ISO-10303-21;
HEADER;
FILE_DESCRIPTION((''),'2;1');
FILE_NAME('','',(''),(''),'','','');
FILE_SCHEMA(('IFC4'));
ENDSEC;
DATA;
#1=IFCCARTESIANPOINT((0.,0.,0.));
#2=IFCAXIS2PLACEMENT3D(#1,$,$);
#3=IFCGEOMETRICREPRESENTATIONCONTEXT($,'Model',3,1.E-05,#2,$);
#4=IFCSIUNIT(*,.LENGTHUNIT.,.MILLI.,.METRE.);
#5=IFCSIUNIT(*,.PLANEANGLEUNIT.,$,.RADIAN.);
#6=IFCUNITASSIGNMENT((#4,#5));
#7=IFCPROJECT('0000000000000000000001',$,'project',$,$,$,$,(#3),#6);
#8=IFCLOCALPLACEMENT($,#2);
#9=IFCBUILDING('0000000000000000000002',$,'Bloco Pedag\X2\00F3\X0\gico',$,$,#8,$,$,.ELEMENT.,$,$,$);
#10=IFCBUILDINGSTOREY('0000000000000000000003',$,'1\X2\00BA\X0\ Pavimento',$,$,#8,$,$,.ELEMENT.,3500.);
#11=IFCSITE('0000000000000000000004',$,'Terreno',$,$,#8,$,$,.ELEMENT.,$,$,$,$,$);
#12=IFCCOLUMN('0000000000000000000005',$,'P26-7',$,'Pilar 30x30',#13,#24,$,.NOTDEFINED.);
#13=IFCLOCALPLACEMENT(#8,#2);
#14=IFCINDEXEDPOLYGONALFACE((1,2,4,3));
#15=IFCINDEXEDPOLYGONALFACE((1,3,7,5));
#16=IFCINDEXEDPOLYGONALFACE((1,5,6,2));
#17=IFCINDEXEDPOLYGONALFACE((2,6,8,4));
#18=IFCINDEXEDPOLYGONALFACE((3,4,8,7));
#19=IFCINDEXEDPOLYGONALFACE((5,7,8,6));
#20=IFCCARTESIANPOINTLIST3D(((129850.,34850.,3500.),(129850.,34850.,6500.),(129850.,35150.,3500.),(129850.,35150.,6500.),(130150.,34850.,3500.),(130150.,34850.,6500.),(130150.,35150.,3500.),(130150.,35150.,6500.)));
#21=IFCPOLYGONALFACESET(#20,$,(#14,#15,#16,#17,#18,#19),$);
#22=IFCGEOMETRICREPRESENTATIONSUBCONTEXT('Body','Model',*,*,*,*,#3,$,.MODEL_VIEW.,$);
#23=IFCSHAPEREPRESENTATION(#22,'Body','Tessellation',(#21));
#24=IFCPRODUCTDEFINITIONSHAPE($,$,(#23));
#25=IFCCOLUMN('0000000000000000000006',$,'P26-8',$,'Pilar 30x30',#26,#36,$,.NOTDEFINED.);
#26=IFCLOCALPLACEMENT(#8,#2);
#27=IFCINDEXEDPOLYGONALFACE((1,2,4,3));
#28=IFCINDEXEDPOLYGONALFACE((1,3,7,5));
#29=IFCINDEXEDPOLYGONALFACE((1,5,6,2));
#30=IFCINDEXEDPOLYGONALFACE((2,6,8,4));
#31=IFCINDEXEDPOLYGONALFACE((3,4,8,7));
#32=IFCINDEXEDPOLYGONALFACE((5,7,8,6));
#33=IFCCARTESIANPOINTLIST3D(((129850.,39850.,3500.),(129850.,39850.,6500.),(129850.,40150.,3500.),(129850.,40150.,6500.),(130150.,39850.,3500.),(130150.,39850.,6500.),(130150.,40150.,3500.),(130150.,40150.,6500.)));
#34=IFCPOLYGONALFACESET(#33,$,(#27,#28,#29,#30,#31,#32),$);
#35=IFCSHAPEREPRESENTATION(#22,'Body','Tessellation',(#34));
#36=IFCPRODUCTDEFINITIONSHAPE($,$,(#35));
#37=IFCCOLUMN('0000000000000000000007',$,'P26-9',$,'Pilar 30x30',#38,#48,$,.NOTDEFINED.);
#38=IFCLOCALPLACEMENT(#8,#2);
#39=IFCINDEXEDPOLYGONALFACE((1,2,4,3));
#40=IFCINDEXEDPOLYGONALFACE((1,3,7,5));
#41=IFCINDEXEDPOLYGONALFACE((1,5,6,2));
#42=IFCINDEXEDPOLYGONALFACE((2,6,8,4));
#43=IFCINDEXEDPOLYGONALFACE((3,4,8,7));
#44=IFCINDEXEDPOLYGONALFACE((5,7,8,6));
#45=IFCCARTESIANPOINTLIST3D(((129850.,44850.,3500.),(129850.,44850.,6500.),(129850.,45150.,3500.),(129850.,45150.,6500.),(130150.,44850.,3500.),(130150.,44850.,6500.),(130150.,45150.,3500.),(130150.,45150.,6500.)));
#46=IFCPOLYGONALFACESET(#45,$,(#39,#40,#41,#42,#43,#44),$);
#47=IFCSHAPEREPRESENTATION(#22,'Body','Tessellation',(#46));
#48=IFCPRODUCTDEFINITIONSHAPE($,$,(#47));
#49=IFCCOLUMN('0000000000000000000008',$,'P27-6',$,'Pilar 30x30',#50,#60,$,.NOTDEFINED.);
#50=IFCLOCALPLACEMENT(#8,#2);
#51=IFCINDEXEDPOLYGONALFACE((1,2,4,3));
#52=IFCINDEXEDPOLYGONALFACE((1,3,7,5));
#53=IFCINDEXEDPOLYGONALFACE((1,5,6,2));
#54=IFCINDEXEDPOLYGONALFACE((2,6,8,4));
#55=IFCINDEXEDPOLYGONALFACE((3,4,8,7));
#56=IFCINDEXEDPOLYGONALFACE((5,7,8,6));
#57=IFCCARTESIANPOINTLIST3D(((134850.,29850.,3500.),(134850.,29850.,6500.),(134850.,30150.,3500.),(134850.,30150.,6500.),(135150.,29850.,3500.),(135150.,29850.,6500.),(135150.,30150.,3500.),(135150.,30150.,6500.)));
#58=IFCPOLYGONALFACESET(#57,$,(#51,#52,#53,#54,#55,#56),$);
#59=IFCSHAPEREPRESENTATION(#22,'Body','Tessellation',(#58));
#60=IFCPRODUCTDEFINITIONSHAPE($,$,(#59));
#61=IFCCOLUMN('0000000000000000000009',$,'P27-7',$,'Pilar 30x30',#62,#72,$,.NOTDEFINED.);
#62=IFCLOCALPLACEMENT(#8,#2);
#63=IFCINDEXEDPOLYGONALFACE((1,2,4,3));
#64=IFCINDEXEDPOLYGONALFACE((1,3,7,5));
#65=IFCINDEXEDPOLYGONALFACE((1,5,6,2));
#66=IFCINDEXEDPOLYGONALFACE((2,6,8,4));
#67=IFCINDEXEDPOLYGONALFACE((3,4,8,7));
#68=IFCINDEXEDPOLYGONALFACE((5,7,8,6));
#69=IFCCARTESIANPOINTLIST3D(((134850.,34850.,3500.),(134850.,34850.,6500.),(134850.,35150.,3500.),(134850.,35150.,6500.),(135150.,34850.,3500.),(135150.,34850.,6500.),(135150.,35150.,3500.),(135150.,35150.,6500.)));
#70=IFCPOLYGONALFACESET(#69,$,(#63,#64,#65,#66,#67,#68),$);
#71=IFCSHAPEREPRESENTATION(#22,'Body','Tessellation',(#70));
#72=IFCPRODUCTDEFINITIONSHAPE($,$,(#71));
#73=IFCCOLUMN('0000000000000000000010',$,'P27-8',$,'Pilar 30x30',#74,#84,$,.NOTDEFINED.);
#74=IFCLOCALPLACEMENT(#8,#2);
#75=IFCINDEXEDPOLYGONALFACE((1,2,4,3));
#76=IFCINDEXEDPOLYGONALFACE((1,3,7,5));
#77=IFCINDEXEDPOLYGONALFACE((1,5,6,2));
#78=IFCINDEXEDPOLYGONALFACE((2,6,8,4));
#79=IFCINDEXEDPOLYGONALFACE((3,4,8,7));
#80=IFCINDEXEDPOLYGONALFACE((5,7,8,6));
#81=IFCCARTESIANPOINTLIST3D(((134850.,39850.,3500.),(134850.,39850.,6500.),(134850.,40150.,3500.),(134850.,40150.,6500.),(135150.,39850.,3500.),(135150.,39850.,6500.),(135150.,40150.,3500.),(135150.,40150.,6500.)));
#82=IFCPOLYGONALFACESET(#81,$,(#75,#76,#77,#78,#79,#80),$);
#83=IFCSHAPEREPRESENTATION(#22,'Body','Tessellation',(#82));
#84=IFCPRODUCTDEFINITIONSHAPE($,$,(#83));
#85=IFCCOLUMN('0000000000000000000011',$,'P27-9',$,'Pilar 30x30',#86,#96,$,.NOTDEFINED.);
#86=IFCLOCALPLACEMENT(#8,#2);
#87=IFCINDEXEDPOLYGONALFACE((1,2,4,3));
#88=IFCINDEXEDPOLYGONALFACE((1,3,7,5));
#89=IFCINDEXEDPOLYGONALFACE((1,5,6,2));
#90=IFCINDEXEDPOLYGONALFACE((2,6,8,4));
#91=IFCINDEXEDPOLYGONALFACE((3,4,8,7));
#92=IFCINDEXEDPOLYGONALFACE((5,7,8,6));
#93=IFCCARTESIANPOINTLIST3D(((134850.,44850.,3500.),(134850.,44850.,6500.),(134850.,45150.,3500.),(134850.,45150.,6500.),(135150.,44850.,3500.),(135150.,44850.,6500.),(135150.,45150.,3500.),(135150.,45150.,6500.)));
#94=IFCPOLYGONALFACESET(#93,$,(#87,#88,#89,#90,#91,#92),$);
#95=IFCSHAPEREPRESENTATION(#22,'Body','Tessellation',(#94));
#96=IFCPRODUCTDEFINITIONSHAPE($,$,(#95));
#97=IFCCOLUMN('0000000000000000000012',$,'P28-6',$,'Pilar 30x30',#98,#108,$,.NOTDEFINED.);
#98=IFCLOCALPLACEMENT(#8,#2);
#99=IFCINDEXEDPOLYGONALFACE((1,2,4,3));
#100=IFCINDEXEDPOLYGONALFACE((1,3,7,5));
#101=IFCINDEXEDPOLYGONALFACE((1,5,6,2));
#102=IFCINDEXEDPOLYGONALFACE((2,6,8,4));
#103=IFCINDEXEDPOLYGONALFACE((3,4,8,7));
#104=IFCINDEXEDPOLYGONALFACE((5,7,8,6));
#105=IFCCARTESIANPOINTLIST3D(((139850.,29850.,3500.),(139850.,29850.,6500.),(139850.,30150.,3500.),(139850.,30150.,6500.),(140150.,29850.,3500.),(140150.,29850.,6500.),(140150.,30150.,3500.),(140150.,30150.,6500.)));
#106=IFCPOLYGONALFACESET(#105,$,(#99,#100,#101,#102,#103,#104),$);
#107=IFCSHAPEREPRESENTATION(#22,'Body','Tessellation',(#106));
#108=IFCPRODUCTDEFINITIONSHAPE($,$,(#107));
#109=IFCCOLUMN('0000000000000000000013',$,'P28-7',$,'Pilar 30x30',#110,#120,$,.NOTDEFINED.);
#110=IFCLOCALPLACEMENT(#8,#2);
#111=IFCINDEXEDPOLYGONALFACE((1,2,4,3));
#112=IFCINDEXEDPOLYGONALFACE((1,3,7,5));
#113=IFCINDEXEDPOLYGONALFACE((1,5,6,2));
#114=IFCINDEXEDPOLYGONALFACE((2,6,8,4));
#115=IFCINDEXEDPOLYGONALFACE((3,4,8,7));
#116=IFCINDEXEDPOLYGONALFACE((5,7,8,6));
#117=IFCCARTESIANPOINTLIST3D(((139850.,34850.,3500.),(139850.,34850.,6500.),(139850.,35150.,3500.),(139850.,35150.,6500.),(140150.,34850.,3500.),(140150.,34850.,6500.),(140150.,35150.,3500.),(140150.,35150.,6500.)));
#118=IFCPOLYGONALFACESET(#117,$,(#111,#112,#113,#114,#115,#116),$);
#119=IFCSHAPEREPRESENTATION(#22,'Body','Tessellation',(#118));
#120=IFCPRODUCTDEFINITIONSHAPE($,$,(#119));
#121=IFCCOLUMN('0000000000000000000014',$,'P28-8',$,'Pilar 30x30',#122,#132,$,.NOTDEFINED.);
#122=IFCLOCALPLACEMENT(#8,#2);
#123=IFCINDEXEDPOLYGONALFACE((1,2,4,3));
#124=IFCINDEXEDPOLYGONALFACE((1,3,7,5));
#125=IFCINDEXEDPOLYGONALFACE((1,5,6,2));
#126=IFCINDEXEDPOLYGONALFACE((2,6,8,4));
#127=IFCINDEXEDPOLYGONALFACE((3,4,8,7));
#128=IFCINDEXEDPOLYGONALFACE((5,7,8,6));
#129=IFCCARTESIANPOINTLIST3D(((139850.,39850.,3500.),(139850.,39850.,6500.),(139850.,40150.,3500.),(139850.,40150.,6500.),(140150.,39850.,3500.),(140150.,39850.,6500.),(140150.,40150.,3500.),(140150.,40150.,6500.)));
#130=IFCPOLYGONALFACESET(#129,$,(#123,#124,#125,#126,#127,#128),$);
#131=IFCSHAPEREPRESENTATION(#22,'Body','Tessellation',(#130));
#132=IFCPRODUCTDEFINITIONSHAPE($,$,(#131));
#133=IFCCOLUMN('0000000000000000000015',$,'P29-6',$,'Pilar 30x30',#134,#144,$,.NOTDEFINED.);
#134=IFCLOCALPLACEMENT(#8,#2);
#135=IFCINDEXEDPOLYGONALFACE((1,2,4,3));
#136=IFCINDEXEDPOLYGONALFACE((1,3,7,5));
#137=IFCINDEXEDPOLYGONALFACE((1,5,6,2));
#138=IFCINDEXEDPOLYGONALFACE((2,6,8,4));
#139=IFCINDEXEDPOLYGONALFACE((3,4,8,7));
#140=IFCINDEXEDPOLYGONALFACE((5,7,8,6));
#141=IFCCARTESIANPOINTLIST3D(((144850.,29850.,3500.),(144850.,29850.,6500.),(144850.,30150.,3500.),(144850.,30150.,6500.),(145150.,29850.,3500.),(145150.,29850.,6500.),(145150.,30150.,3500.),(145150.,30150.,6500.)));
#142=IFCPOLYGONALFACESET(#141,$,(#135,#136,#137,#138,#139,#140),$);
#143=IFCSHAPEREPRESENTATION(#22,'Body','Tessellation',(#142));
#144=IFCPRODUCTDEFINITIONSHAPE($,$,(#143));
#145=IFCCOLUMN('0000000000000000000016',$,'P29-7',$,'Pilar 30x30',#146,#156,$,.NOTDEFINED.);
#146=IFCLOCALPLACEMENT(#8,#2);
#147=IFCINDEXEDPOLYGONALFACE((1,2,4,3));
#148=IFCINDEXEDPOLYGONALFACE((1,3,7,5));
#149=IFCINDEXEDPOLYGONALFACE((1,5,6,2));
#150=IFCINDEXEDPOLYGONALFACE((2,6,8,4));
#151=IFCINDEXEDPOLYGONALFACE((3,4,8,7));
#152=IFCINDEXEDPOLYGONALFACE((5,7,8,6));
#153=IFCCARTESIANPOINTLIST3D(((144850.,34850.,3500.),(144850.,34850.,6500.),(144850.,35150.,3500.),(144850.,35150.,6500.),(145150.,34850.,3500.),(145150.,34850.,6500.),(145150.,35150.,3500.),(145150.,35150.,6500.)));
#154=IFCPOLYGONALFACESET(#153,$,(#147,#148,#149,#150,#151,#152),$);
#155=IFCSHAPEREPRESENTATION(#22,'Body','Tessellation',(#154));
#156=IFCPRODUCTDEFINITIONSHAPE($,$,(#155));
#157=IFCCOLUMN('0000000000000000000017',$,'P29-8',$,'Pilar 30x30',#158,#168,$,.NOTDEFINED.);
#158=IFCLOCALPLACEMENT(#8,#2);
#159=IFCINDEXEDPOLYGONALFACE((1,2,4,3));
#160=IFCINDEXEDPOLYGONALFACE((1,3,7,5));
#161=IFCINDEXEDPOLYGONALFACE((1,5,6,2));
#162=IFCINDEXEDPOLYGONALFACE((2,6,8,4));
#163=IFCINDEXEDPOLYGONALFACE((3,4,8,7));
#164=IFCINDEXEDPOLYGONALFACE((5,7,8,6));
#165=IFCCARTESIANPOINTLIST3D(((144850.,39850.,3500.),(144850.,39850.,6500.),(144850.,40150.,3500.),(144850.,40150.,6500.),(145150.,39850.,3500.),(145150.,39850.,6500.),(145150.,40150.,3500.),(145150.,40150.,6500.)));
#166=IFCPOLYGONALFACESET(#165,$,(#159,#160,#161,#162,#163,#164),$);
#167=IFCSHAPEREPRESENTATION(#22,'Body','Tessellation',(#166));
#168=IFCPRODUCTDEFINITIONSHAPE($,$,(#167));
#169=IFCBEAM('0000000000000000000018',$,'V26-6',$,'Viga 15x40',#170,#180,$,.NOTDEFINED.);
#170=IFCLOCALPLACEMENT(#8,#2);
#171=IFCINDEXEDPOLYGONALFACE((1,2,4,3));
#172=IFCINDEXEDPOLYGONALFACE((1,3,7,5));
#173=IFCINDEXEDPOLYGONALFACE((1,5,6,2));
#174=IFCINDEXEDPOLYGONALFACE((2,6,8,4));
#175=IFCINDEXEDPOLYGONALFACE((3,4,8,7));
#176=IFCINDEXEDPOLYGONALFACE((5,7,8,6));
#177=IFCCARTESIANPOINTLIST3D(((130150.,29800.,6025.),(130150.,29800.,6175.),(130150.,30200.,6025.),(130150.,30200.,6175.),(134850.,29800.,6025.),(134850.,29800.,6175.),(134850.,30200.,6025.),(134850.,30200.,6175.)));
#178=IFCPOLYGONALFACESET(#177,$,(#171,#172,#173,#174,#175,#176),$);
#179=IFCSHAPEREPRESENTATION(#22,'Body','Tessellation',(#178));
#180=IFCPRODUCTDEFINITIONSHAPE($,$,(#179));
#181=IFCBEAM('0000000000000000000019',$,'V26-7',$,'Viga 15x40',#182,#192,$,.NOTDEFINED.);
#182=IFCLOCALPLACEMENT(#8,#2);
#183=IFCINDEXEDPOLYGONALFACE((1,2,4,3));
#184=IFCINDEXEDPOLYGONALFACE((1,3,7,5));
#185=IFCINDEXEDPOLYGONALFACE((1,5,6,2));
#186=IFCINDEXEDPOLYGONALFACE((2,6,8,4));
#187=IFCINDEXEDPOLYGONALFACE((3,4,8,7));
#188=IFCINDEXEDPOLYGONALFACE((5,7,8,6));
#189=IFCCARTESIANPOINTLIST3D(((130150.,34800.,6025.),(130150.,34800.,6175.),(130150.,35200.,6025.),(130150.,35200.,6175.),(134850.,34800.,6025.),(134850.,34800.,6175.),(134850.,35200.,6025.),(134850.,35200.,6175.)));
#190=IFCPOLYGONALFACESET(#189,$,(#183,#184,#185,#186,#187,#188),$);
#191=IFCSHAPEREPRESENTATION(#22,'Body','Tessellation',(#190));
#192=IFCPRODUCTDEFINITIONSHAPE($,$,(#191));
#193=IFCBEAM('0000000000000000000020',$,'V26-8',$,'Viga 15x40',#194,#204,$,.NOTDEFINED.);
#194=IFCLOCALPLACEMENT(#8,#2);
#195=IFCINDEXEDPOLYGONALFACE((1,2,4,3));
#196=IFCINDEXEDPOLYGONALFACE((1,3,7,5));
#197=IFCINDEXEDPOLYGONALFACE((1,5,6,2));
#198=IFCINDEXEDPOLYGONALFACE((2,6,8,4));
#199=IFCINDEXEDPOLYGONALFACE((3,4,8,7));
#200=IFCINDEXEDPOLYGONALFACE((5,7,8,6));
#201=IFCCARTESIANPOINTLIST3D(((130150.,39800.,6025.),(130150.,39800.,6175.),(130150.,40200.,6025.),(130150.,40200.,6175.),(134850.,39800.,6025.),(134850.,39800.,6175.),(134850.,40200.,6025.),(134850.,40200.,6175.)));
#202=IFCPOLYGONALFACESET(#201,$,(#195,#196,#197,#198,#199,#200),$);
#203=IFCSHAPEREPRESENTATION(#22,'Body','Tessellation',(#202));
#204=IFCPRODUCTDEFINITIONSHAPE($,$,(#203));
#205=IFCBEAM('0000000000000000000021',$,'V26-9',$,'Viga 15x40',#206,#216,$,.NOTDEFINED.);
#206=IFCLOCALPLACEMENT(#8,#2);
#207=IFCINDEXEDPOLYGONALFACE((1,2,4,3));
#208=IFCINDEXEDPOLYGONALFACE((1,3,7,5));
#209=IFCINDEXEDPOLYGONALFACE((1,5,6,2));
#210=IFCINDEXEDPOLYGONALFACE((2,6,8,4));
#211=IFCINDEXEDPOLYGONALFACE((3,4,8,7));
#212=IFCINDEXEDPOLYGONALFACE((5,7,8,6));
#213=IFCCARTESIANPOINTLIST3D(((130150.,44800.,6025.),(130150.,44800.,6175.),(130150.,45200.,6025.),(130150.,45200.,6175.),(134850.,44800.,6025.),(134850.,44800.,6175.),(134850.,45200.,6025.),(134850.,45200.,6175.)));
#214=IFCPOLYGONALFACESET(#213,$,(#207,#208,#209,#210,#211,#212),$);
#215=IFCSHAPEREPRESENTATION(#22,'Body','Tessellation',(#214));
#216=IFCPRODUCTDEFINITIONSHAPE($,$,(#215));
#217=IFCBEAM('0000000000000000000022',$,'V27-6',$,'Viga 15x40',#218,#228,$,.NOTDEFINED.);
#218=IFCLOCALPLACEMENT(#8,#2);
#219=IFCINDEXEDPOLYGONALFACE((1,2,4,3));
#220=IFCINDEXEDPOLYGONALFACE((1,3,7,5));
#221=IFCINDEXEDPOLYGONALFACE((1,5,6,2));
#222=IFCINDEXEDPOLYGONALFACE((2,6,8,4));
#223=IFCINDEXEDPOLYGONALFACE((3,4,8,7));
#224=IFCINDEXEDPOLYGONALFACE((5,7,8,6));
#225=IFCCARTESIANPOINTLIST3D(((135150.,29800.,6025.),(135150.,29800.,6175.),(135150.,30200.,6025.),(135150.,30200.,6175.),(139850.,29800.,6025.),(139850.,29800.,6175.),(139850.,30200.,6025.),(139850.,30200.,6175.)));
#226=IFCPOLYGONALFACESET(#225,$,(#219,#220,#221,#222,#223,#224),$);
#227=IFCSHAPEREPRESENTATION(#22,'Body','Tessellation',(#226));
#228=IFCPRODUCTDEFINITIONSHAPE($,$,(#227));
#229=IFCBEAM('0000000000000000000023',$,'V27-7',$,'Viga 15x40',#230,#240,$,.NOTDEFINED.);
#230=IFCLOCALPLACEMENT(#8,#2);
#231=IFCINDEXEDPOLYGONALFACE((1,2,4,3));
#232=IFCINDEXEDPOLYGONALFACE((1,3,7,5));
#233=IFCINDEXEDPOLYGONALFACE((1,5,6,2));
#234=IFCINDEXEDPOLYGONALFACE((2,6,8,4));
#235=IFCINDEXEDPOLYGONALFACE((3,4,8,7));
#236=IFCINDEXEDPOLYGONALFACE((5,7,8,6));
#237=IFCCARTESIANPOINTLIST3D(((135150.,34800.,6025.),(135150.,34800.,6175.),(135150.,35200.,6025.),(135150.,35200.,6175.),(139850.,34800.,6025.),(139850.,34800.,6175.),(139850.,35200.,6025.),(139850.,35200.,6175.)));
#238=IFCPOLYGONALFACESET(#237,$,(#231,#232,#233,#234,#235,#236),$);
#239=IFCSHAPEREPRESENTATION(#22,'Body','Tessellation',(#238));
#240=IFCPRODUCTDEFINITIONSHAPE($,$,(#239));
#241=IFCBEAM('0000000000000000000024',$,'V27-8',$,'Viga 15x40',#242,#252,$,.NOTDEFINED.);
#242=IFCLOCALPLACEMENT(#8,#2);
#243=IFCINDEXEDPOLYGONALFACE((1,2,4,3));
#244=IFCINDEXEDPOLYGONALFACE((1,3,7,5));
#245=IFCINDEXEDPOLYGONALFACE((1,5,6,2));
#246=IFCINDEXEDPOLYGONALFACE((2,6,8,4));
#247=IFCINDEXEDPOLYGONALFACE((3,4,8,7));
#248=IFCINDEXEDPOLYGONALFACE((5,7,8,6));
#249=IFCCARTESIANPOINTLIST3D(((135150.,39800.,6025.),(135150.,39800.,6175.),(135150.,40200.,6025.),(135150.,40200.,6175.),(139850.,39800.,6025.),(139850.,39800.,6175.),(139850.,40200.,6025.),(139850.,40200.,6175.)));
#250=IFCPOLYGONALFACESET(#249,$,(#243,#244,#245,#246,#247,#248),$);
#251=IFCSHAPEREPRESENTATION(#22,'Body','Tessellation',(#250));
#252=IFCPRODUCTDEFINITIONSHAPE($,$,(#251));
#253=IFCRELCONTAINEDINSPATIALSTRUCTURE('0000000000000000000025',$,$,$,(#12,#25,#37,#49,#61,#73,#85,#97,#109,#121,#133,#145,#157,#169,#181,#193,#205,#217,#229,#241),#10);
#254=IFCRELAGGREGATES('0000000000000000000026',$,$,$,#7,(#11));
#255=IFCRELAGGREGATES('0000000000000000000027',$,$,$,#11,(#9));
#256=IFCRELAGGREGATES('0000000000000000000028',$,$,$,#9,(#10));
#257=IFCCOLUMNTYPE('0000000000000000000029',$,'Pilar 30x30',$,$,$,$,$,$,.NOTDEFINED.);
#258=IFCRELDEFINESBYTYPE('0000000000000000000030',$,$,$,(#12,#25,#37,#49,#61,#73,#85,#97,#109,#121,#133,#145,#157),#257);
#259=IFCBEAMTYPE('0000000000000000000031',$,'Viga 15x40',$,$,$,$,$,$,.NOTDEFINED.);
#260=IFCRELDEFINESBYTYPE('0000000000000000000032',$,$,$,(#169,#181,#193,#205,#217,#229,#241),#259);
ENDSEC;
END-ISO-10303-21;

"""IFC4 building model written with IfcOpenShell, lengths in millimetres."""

from ifc_helpers import new_model, si_unit, frame, origin, origin_2d, place, context, subcontext, project, spatial, rectangle, extrude, type_object, element, save


model = new_model("IFC4")

# Units and contexts
model_context = context("Model", 3, precision=1e-05, world=origin())
body_context = subcontext(model_context, "Body", "Model", "MODEL_VIEW")
ifc_project = project(units=[si_unit("LENGTHUNIT", "METRE", prefix="MILLI"), si_unit("PLANEANGLEUNIT", "RADIAN")], contexts=[model_context])

# Site, building, storey
placement = place(None, origin())
site = spatial("IfcSite", under=ifc_project, at=placement, Name="Terreno", CompositionType="ELEMENT")
building = spatial("IfcBuilding", under=site, at=placement, Name="Bloco Pedagógico", CompositionType="ELEMENT")
storey = spatial("IfcBuildingStorey", under=building, at=placement, Name="1º Pavimento", CompositionType="ELEMENT", Elevation=3500.0)

# Columns
column_type = type_object("IfcColumnType", Name="Pilar 30x30", PredefinedType="NOTDEFINED")
for number, where, z_axis, x_axis, name in (
    (1, (130000.0, 35000.0, 3500.0), (0.0, 0.0, 1.0), (1.0, 0.0, 0.0), "P26-7"),
    (2, (130000.0, 40000.0, 3500.0), (0.0, 0.0, 1.0), (1.0, 0.0, 0.0), "P26-8"),
    (3, (130000.0, 45000.0, 3500.0), (0.0, 0.0, 1.0), (1.0, 0.0, 0.0), "P26-9"),
    (4, (135000.0, 30000.0, 3500.0), (0.0, 0.0, 1.0), (1.0, 0.0, 0.0), "P27-6"),
    (5, (135000.0, 35000.0, 3500.0), (0.0, 0.0, 1.0), (1.0, 0.0, 0.0), "P27-7"),
    (6, (135000.0, 40000.0, 3500.0), (0.0, 0.0, 1.0), (1.0, 0.0, 0.0), "P27-8"),
    (7, (135000.0, 45000.0, 3500.0), (0.0, 0.0, 1.0), (1.0, 0.0, 0.0), "P27-9"),
    (8, (140000.0, 30000.0, 3500.0), (0.0, 0.0, 1.0), (1.0, 0.0, 0.0), "P28-6"),
    (9, (140000.0, 35000.0, 3500.0), (0.0, 0.0, 1.0), (1.0, 0.0, 0.0), "P28-7"),
    (10, (140000.0, 40000.0, 3500.0), (0.0, 0.0, 1.0), (1.0, 0.0, 0.0), "P28-8"),
    (11, (145000.0, 30000.0, 3500.0), (0.0, 0.0, 1.0), (1.0, 0.0, 0.0), "P29-6"),
    (12, (145000.0, 35000.0, 3500.0), (0.0, 0.0, 1.0), (1.0, 0.0, 0.0), "P29-7"),
    (13, (145000.0, 40000.0, 3500.0), (0.0, 0.0, 1.0), (1.0, 0.0, 0.0), "P29-8"),
):
    element("IfcColumn", number, at=place(None, frame(where, z_axis=z_axis, x_axis=x_axis)), inside=storey, type_object=column_type, Name=name, ObjectType="Pilar 30x30", PredefinedType="NOTDEFINED", context=body_context, shape_type="SweptSolid", body=[
        extrude(rectangle(XDim=300.0, YDim=300.0, at=origin_2d()), None, (0.0, 0.0, 1.0), 3000.0),
    ])

# Beams
beam_type = type_object("IfcBeamType", Name="Viga 15x40", PredefinedType="NOTDEFINED")
for number, where, z_axis, x_axis, name in (
    (14, (130150.0, 30000.0, 6100.0), (1.0, 0.0, 0.0), (0.0, 1.0, 0.0), "V26-6"),
    (15, (130150.0, 35000.0, 6100.0), (1.0, 0.0, 0.0), (0.0, 1.0, 0.0), "V26-7"),
    (16, (130150.0, 40000.0, 6100.0), (1.0, 0.0, 0.0), (0.0, 1.0, 0.0), "V26-8"),
    (17, (130150.0, 45000.0, 6100.0), (1.0, 0.0, 0.0), (0.0, 1.0, 0.0), "V26-9"),
    (18, (135150.0, 30000.0, 6100.0), (1.0, 0.0, 0.0), (0.0, 1.0, 0.0), "V27-6"),
    (19, (135150.0, 35000.0, 6100.0), (1.0, 0.0, 0.0), (0.0, 1.0, 0.0), "V27-7"),
    (20, (135150.0, 40000.0, 6100.0), (1.0, 0.0, 0.0), (0.0, 1.0, 0.0), "V27-8"),
):
    element("IfcBeam", number, at=place(None, frame(where, z_axis=z_axis, x_axis=x_axis)), inside=storey, type_object=beam_type, Name=name, ObjectType="Viga 15x40", PredefinedType="NOTDEFINED", context=body_context, shape_type="SweptSolid", body=[
        extrude(rectangle(XDim=400.0, YDim=150.0, at=origin_2d()), None, (0.0, 0.0, 1.0), 4700.0),
    ])

save(model, "model.ifc")
